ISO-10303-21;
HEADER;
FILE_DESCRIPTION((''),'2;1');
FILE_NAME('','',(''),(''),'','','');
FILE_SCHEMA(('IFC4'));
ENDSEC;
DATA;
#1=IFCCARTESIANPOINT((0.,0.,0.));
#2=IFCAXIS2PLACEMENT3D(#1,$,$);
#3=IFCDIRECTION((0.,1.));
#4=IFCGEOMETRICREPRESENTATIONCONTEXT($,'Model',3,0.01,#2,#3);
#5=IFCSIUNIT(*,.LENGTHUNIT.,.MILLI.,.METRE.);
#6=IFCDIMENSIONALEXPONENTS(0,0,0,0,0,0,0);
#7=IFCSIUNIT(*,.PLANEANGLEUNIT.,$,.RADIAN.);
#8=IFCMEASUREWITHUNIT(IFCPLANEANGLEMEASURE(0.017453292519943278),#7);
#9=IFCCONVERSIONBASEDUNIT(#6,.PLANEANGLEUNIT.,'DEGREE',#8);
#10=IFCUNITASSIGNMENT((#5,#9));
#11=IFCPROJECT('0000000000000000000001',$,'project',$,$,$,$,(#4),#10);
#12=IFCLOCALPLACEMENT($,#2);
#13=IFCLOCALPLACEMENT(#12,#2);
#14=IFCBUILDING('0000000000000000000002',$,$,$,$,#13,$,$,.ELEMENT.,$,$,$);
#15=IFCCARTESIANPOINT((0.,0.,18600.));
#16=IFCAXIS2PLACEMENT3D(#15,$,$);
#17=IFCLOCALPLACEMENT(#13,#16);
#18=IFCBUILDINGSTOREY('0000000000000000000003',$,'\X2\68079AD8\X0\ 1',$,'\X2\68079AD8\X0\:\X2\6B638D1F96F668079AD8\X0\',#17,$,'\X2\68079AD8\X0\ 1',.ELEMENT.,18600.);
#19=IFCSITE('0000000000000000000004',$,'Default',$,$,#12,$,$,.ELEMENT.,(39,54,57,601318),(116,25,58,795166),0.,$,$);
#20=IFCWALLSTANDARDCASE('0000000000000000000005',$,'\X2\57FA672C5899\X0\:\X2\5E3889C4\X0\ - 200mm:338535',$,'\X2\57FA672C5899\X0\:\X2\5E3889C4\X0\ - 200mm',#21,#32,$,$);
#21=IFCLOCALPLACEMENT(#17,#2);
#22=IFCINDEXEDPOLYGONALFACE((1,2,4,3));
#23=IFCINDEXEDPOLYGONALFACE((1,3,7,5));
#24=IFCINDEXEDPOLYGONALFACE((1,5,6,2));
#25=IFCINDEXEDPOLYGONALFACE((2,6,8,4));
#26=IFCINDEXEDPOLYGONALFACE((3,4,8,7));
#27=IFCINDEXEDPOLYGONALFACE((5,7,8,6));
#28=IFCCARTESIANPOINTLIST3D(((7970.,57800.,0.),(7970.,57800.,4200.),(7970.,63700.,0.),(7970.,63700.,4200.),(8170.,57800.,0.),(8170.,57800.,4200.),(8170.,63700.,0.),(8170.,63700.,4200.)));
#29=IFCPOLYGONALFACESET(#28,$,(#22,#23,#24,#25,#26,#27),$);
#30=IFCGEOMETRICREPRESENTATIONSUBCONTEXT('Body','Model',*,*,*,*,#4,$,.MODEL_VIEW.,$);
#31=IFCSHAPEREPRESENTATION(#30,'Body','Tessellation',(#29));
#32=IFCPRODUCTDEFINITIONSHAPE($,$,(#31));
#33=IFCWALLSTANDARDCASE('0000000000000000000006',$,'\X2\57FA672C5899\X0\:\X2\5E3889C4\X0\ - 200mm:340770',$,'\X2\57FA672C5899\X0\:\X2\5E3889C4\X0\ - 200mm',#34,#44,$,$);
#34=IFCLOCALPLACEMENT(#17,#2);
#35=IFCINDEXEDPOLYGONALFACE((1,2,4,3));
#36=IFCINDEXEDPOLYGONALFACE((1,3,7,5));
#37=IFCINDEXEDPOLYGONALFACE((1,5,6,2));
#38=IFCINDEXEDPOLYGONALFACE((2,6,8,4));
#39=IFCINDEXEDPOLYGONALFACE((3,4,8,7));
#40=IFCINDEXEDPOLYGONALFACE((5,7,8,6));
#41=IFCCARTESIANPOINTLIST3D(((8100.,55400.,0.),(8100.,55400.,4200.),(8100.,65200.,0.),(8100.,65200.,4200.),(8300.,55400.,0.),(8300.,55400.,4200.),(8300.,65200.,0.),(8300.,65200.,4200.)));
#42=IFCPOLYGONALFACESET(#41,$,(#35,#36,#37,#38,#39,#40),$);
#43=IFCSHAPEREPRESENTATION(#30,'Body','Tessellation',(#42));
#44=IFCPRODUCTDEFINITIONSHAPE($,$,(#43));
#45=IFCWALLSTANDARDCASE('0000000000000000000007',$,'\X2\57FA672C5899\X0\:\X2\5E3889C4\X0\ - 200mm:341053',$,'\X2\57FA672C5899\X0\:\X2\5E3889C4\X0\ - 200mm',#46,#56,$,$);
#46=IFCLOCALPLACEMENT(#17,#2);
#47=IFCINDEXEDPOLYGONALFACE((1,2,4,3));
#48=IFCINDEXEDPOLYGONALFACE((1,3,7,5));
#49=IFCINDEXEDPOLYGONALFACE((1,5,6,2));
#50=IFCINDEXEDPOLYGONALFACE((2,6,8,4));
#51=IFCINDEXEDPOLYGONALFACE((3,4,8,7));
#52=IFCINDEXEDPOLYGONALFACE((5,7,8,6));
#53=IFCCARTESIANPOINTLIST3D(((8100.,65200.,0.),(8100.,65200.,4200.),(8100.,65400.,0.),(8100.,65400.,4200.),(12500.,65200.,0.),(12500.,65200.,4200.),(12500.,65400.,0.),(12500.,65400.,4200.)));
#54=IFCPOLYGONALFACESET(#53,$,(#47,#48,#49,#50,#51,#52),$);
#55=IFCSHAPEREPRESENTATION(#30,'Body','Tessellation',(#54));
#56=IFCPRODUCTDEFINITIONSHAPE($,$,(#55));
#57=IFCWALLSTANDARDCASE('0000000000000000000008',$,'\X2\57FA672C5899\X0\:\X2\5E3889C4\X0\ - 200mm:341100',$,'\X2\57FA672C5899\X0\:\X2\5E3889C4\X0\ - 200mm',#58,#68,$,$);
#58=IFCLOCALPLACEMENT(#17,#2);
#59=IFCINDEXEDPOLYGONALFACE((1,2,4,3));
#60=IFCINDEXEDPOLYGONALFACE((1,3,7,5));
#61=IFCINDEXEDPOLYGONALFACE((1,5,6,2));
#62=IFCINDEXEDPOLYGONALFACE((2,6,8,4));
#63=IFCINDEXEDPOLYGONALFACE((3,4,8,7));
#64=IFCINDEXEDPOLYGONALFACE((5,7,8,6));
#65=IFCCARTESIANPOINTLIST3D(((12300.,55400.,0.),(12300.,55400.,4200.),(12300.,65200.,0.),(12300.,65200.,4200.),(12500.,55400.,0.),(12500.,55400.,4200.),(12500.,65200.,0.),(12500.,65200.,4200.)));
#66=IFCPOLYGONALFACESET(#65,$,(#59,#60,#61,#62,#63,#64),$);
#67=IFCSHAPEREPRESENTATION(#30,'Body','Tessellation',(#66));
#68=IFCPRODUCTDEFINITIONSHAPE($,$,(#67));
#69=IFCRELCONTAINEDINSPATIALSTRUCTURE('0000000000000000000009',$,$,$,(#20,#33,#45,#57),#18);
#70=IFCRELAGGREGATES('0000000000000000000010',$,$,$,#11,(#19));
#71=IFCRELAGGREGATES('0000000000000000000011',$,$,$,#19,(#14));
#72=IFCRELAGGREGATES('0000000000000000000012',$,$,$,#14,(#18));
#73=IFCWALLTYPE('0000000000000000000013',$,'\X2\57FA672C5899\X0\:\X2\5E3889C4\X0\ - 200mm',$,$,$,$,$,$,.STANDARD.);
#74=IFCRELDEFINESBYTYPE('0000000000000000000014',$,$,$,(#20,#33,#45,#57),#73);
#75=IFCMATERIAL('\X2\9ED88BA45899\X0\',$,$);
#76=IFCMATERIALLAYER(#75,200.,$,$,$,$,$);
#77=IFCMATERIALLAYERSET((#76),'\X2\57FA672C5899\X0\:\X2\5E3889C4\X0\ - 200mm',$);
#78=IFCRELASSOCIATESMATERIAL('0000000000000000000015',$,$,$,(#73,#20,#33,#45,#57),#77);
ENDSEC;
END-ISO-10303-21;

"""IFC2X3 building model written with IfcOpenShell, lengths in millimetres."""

from ifc_helpers import new_model, entity, si_unit, converted_unit, direction, frame, frame_2d, origin, place, context, subcontext, project, spatial, rectangle, extrude, material, layer, layer_set, layer_usage, type_object, element, save


model = new_model("IFC2X3")

# Units and contexts
model_context = context("Model", 3, precision=0.01, world=origin(), true_north=direction((0.0, 1.0)))
body_context = subcontext(model_context, "Body", "Model", "MODEL_VIEW")
ifc_project = project(units=[si_unit("LENGTHUNIT", "METRE", prefix="MILLI"), converted_unit("PLANEANGLEUNIT", "DEGREE", entity("IfcPlaneAngleMeasure", 0.017453292519943278), si_unit("PLANEANGLEUNIT", "RADIAN"), dimensions=[0, 0, 0, 0, 0, 0, 0])], contexts=[model_context])

# Site, building, storey
site_placement = place(None, origin())
site = spatial("IfcSite", under=ifc_project, at=site_placement, Name="Default", CompositionType="ELEMENT", RefLatitude=(39, 54, 57, 601318), RefLongitude=(116, 25, 58, 795166), RefElevation=0.0)
building_placement = place(site_placement, origin())
building = spatial("IfcBuilding", under=site, at=building_placement, CompositionType="ELEMENT")
storey_placement = place(building_placement, frame((0.0, 0.0, 18600.0)))
storey = spatial("IfcBuildingStorey", under=building, at=storey_placement, Name="标高 1", ObjectType="标高:正负零标高", LongName="标高 1", CompositionType="ELEMENT", Elevation=18600.0)

# Walls
ifc_material_1 = material(Name="默认墙")
ifc_layer = layer(ifc_material_1, 200.0)
ifc_layer_set = layer_set([ifc_layer], Name="基本墙:常规 - 200mm")
ifc_layer_usage_1 = layer_usage(ifc_layer_set, "AXIS2", "NEGATIVE", 100.0)
wall_type = type_object("IfcWallType", Name="基本墙:常规 - 200mm", PredefinedType="STANDARD", material=ifc_layer_set)
wall_1_placement = place(storey_placement, frame((8070.0, 63700.0, 0.0), z_axis=(0.0, 0.0, 1.0), x_axis=(0.0, -1.0, 0.0)))
element("IfcWallStandardCase", 1, at=wall_1_placement, inside=storey, type_object=wall_type, material=ifc_layer_usage_1, Name="基本墙:常规 - 200mm:338535", ObjectType="基本墙:常规 - 200mm", context=body_context, shape_type="SweptSolid", body=[
    extrude(rectangle(XDim=5900.0, YDim=200.0, at=frame_2d((2950.0, 0.0), x_axis=(-1.0, 0.0))), origin(), (0.0, 0.0, 1.0), 4200.0),
])
ifc_layer_usage_2 = layer_usage(ifc_layer_set, "AXIS2", "NEGATIVE", 100.0)
wall_2_placement = place(storey_placement, frame((8200.0, 65200.0, 0.0), z_axis=(0.0, 0.0, 1.0), x_axis=(0.0, -1.0, 0.0)))
element("IfcWallStandardCase", 2, at=wall_2_placement, inside=storey, type_object=wall_type, material=ifc_layer_usage_2, Name="基本墙:常规 - 200mm:340770", ObjectType="基本墙:常规 - 200mm", context=body_context, shape_type="SweptSolid", body=[
    extrude(rectangle(XDim=9800.0, YDim=200.0, at=frame_2d((4900.0, 0.0), x_axis=(-1.0, 0.0))), origin(), (0.0, 0.0, 1.0), 4200.0),
])
ifc_layer_usage_3 = layer_usage(ifc_layer_set, "AXIS2", "NEGATIVE", 100.0)
wall_3_placement = place(storey_placement, frame((8100.0, 65300.0, 0.0)))
element("IfcWallStandardCase", 3, at=wall_3_placement, inside=storey, type_object=wall_type, material=ifc_layer_usage_3, Name="基本墙:常规 - 200mm:341053", ObjectType="基本墙:常规 - 200mm", context=body_context, shape_type="SweptSolid", body=[
    extrude(rectangle(XDim=4400.0, YDim=200.0, at=frame_2d((2200.0, 0.0), x_axis=(-1.0, 0.0))), origin(), (0.0, 0.0, 1.0), 4200.0),
])
ifc_layer_usage_4 = layer_usage(ifc_layer_set, "AXIS2", "NEGATIVE", 100.0)
wall_4_placement = place(storey_placement, frame((12400.0, 65200.0, 0.0), z_axis=(0.0, 0.0, 1.0), x_axis=(0.0, -1.0, 0.0)))
element("IfcWallStandardCase", 4, at=wall_4_placement, inside=storey, type_object=wall_type, material=ifc_layer_usage_4, Name="基本墙:常规 - 200mm:341100", ObjectType="基本墙:常规 - 200mm", context=body_context, shape_type="SweptSolid", body=[
    extrude(rectangle(XDim=9800.0, YDim=200.0, at=frame_2d((4900.0, 0.0), x_axis=(-1.0, 0.0))), origin(), (0.0, 0.0, 1.0), 4200.0),
])

save(model, "model.ifc")
